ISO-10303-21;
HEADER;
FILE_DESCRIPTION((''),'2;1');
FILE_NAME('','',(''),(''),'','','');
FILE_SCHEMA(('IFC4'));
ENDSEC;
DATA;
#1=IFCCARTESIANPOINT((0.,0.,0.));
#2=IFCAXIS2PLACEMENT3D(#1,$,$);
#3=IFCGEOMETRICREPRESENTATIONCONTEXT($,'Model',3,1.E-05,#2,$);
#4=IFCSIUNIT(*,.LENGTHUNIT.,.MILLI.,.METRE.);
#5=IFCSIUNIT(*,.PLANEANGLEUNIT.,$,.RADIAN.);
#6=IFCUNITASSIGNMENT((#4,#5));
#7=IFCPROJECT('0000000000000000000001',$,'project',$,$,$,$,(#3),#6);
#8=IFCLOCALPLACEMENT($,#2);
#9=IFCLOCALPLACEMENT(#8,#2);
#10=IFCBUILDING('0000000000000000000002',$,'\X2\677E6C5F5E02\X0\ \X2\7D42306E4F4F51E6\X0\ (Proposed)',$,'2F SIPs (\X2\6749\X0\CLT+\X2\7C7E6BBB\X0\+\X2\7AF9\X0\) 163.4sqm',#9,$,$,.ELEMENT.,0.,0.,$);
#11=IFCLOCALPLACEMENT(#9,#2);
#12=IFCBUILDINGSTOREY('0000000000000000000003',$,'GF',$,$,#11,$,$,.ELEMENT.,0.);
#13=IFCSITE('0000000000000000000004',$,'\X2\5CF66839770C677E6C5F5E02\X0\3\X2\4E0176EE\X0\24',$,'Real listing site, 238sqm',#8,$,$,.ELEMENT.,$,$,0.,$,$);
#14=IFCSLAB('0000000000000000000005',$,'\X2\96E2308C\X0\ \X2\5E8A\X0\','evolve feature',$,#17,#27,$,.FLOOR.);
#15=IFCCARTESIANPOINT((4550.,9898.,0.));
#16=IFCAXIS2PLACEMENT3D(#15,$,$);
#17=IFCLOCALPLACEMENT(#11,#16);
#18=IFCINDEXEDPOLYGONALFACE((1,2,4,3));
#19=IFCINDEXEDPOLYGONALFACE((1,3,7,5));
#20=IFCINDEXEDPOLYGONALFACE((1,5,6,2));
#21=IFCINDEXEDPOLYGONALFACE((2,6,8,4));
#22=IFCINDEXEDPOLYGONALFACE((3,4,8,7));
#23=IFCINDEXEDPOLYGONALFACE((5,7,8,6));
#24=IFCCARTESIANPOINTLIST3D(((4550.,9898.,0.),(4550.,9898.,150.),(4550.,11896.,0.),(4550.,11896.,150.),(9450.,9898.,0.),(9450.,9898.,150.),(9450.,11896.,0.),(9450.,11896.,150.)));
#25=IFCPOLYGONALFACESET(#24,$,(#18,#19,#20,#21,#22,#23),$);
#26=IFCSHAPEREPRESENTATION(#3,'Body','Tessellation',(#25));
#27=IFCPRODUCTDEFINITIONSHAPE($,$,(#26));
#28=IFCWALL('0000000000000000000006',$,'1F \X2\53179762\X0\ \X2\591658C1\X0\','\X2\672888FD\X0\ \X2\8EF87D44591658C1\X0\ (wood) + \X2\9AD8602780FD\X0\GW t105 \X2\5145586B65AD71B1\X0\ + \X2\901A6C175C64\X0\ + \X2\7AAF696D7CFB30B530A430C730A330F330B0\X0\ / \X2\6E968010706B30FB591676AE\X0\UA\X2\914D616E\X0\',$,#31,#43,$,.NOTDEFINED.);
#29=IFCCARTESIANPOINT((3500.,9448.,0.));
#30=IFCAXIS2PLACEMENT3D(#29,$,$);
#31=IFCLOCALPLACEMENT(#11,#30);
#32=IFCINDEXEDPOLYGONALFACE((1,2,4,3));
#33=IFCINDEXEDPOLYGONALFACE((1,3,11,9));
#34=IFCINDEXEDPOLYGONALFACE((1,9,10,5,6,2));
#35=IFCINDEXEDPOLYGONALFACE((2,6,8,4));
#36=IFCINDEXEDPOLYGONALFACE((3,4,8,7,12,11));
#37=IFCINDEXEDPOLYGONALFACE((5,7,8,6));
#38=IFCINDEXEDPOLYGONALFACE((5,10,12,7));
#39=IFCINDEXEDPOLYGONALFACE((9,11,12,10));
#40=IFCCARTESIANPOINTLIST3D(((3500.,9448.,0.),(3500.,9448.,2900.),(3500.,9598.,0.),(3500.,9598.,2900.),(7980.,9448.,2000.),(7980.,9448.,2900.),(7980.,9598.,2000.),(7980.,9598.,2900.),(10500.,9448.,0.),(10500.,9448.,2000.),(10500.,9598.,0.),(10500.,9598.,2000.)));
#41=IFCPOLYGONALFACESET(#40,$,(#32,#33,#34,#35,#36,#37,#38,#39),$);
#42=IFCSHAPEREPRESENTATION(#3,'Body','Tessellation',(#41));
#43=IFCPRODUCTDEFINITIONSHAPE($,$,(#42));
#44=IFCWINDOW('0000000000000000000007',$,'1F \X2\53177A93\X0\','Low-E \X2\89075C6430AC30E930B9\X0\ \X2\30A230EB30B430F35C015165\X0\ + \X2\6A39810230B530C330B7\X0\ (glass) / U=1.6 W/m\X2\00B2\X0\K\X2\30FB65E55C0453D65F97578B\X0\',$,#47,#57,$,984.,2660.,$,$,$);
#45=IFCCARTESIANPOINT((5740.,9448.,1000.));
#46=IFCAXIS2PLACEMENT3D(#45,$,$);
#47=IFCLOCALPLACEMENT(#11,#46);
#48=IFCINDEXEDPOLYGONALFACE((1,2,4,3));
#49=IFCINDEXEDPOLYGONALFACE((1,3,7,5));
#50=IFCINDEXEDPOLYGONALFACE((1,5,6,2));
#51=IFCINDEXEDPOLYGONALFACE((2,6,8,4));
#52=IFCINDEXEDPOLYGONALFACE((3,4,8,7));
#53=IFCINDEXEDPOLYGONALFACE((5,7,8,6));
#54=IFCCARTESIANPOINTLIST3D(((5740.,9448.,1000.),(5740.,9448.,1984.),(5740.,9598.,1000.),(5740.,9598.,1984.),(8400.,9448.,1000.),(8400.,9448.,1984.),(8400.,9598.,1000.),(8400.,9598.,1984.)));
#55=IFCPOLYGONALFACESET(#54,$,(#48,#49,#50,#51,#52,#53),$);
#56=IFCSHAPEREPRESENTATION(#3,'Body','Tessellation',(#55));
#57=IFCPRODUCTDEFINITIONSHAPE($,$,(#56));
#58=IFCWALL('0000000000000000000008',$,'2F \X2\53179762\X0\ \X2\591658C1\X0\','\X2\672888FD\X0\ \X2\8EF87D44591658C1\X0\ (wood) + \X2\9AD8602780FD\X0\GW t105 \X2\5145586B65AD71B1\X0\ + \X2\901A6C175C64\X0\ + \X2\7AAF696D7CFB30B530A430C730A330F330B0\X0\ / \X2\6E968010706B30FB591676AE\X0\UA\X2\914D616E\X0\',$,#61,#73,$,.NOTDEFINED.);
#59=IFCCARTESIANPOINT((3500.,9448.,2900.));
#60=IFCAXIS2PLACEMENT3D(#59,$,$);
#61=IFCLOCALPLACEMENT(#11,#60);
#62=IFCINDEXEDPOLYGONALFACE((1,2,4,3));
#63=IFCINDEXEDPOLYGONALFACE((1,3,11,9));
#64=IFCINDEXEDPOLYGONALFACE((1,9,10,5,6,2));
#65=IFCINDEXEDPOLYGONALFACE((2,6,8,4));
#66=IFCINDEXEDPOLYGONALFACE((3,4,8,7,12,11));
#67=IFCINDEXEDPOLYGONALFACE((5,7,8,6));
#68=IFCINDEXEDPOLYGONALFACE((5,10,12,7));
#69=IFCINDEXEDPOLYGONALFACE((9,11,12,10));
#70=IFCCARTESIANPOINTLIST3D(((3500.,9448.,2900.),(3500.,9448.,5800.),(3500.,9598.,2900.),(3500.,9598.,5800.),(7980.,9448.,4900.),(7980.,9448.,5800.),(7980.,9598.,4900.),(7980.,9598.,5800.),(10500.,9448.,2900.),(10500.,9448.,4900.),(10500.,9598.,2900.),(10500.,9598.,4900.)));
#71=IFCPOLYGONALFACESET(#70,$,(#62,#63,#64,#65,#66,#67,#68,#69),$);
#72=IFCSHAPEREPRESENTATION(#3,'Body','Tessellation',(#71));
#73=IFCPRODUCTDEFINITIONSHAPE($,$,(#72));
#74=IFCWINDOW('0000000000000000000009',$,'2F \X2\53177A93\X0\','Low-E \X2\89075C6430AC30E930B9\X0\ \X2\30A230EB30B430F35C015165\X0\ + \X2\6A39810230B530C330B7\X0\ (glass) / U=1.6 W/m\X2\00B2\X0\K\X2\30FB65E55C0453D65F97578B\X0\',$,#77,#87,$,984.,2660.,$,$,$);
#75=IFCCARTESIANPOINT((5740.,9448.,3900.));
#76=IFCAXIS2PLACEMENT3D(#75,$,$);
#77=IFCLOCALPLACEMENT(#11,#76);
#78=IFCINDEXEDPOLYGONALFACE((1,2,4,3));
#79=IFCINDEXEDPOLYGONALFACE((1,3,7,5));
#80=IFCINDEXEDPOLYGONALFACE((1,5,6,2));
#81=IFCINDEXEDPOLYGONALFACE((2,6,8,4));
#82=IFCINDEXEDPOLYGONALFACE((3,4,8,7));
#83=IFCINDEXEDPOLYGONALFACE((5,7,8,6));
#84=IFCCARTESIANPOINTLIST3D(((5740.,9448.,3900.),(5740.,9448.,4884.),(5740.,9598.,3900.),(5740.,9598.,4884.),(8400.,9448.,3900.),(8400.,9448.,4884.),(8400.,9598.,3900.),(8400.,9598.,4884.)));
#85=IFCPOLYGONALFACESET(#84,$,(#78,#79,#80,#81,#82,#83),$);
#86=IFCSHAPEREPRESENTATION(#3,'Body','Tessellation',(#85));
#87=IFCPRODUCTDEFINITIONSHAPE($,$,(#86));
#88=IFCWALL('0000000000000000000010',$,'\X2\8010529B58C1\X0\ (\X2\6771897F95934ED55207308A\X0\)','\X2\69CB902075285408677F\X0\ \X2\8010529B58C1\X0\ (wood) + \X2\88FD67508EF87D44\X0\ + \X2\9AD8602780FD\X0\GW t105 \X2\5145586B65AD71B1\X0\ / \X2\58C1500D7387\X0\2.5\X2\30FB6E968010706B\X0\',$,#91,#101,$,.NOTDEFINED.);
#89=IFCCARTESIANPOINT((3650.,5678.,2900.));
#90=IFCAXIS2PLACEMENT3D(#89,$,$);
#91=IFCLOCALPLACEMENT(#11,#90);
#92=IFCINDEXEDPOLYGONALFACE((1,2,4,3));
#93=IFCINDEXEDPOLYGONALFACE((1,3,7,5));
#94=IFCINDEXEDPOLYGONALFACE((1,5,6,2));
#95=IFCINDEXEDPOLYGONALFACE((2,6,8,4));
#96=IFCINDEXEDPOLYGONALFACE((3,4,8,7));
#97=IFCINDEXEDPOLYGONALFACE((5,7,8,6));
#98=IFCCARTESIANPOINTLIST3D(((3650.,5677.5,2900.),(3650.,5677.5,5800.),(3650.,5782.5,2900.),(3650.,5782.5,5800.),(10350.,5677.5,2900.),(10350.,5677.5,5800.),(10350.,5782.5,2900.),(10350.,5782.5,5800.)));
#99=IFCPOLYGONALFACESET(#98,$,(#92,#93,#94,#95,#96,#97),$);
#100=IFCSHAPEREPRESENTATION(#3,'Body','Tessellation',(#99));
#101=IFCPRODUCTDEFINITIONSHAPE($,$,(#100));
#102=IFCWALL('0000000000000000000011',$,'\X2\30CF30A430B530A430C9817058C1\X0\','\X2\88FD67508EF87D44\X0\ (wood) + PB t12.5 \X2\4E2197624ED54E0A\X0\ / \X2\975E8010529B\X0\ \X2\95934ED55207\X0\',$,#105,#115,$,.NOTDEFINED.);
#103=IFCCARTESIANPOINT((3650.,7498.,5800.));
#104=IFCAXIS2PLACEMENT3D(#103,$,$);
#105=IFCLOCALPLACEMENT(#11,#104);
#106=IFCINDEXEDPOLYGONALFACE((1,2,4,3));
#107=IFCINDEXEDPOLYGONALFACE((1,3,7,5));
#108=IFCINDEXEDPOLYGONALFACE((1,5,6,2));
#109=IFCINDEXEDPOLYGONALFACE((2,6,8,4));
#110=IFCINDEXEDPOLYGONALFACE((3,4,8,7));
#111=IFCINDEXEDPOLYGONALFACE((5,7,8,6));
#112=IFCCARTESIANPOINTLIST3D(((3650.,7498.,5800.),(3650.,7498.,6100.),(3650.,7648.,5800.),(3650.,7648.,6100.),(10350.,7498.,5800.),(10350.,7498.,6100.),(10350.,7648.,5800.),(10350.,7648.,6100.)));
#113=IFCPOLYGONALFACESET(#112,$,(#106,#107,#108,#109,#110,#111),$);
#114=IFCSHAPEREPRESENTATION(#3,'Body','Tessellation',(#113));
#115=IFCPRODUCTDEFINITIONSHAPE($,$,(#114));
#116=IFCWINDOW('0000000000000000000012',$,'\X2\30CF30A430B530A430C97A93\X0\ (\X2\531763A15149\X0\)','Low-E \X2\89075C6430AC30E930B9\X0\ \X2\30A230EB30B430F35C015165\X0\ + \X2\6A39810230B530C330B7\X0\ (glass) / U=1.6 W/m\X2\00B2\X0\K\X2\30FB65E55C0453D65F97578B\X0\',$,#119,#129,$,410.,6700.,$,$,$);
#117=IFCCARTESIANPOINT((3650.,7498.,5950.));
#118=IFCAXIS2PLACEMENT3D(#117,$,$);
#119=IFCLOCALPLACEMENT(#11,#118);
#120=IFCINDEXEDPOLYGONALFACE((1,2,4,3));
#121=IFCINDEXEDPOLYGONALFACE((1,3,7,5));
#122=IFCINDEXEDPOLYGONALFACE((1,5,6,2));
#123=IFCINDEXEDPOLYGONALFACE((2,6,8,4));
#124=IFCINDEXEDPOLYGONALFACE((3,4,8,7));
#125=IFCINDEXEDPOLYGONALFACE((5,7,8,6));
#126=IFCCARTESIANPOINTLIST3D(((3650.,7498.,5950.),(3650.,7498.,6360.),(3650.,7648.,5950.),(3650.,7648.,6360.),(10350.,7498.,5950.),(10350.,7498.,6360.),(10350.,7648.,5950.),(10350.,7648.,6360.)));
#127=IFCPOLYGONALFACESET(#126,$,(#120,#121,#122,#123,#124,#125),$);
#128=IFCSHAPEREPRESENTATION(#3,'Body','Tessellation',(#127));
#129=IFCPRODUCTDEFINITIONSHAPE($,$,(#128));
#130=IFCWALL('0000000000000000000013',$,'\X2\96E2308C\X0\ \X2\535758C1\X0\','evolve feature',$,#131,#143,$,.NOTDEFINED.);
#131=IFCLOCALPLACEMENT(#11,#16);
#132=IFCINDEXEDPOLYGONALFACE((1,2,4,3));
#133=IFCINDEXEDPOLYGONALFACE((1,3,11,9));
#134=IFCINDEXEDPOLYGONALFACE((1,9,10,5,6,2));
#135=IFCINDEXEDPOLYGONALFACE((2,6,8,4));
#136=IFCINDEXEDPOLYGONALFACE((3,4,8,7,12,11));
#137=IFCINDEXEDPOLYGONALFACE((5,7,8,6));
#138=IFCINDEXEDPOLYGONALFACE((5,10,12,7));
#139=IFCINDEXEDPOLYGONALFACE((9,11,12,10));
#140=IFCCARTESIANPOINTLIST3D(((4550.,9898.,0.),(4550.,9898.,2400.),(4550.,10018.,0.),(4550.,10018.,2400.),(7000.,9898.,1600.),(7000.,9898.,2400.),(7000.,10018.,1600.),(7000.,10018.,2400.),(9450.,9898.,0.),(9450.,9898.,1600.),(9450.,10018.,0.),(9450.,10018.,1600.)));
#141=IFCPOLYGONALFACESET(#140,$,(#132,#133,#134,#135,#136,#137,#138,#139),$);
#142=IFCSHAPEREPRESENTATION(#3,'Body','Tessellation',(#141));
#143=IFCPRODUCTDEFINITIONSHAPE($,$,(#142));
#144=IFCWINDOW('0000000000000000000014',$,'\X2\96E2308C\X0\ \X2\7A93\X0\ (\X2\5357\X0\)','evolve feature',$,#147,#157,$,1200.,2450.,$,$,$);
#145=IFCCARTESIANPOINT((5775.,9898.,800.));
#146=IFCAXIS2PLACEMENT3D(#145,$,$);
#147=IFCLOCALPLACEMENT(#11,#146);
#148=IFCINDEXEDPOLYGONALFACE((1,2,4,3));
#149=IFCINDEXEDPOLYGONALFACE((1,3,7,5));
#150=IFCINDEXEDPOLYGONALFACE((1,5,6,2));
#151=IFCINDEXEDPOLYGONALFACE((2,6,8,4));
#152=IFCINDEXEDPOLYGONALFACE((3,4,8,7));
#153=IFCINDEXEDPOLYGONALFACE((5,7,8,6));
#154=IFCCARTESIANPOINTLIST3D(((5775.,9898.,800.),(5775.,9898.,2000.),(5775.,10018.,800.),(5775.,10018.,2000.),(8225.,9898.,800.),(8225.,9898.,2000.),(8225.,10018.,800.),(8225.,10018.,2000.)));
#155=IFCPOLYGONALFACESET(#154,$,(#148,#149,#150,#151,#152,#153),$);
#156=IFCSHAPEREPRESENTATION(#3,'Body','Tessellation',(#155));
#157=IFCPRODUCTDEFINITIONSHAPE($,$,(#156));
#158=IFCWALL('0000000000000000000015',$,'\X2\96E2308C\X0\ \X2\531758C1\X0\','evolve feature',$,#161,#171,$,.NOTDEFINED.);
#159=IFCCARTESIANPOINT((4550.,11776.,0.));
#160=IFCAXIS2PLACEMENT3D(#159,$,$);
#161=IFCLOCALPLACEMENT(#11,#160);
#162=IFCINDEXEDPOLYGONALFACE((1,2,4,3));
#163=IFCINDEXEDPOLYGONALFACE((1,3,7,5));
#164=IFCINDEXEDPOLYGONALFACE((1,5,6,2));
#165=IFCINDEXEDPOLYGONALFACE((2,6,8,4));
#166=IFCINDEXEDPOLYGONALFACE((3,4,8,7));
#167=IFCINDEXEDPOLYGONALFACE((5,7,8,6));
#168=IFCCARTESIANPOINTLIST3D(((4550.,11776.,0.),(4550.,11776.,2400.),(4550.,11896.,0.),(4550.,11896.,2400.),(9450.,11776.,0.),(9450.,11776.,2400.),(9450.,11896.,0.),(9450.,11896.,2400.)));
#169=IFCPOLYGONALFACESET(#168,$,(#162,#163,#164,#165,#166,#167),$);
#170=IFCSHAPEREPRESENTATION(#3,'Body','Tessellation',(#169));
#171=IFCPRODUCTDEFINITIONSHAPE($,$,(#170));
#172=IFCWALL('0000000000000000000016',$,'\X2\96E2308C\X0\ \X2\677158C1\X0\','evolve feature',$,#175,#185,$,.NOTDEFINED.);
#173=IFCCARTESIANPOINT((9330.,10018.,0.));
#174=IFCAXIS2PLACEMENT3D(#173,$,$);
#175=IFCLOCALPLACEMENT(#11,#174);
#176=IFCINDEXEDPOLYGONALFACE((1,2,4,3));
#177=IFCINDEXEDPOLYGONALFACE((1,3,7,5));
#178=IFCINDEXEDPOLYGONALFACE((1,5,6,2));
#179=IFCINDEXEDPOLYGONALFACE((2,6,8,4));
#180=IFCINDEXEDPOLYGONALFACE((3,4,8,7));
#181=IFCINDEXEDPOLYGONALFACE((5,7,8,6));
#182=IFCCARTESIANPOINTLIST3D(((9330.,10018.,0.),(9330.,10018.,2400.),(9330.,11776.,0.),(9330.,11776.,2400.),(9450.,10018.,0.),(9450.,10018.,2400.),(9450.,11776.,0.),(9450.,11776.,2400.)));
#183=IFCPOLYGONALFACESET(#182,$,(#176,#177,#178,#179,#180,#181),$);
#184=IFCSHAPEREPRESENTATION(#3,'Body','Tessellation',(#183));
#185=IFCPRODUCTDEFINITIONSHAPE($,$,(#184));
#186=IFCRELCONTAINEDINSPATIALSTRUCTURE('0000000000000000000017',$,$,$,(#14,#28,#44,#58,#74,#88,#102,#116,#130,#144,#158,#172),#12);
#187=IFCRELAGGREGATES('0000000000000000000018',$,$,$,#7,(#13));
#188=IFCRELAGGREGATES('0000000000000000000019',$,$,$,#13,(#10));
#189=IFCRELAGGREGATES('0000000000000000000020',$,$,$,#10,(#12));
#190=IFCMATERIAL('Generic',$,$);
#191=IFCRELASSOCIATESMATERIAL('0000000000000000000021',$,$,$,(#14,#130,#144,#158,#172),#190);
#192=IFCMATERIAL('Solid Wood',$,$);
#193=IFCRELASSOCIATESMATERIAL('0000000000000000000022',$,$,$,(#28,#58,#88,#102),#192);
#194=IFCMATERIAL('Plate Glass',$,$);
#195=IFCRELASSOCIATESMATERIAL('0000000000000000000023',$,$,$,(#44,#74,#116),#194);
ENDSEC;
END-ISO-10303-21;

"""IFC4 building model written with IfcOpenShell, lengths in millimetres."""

from ifc_helpers import new_model, si_unit, frame, frame_2d, origin, place, context, project, spatial, rectangle, extrude, material, element, fill, save


model = new_model("IFC4")

# Units and contexts
model_context = context("Model", 3, precision=1e-05, world=origin())
ifc_project = project(units=[si_unit("LENGTHUNIT", "METRE", prefix="MILLI"), si_unit("PLANEANGLEUNIT", "RADIAN")], contexts=[model_context])

# Site, building, storey
site_placement = place(None, origin())
site = spatial("IfcSite", under=ifc_project, at=site_placement, Name="島根県松江市3丁目24", ObjectType="Real listing site, 238sqm", CompositionType="ELEMENT", RefElevation=0.0)
building_placement = place(site_placement, origin())
building = spatial("IfcBuilding", under=site, at=building_placement, Name="松江市 終の住処 (Proposed)", ObjectType="2F SIPs (杉CLT+籾殻+竹) 163.4sqm", CompositionType="ELEMENT", ElevationOfRefHeight=0.0, ElevationOfTerrain=0.0)
storey_placement = place(building_placement, origin())
storey = spatial("IfcBuildingStorey", under=building, at=storey_placement, Name="GF", CompositionType="ELEMENT", Elevation=0.0)

# Slab
ifc_material_1 = material(Name="Generic")
slab_placement = place(storey_placement, frame((4550.0, 9898.0, 0.0)))
element("IfcSlab", 1, at=slab_placement, inside=storey, material=ifc_material_1, Name="離れ 床", Description="evolve feature", PredefinedType="FLOOR", context=model_context, shape_type="SweptSolid", body=[
    extrude(rectangle(XDim=4900.0, YDim=1998.0, at=frame_2d((2450.0, 999.0))), frame((4550.0, 9898.0, 0.0)), (0.0, 0.0, 1.0), 150.0),
])

# Wall, opening, window
ifc_material_2 = material(Name="Solid Wood")
wall_1_placement = place(storey_placement, frame((3500.0, 9448.0, 0.0)))
wall_1 = element("IfcWall", 2, at=wall_1_placement, inside=storey, material=ifc_material_2, Name="1F 北面 外壁", Description="木製 軸組外壁 (wood) + 高性能GW t105 充填断熱 + 通気層 + 窯業系サイディング / 準耐火・外皮UA配慮", PredefinedType="NOTDEFINED", context=model_context, shape_type="SweptSolid", body=[
    extrude(rectangle(XDim=7000.0, YDim=150.0, at=frame_2d((3500.0, 75.0))), frame((3500.0, 9448.0, 0.0)), (0.0, 0.0, 1.0), 2900.0),
])
opening_1_placement = place(storey_placement, frame((5740.0, 9448.0, 1000.0)))
opening_1 = element("IfcOpeningElement", 3, at=opening_1_placement, cuts=wall_1, PredefinedType="NOTDEFINED", context=model_context, shape_type="SweptSolid", body=[
    extrude(rectangle(XDim=2660.0, YDim=150.0, at=frame_2d((1330.0, 75.0))), frame((5740.0, 9448.0, 1000.0)), (0.0, 0.0, 1.0), 984.0),
])
ifc_material_3 = material(Name="Plate Glass")
window_1_placement = place(storey_placement, frame((5740.0, 9448.0, 1000.0)))
window_1 = element("IfcWindow", 4, at=window_1_placement, inside=storey, material=ifc_material_3, Name="1F 北窓", Description="Low-E 複層ガラス アルゴン封入 + 樹脂サッシ (glass) / U=1.6 W/m²K・日射取得型", OverallHeight=984.0, OverallWidth=2660.0, context=model_context, shape_type="SweptSolid", body=[
    extrude(rectangle(XDim=2660.0, YDim=150.0, at=frame_2d((1330.0, 75.0))), frame((5740.0, 9448.0, 1000.0)), (0.0, 0.0, 1.0), 984.0),
])
fill(opening_1, window_1)

# Wall, opening, window
wall_2_placement = place(storey_placement, frame((3500.0, 9448.0, 2900.0)))
wall_2 = element("IfcWall", 5, at=wall_2_placement, inside=storey, material=ifc_material_2, Name="2F 北面 外壁", Description="木製 軸組外壁 (wood) + 高性能GW t105 充填断熱 + 通気層 + 窯業系サイディング / 準耐火・外皮UA配慮", PredefinedType="NOTDEFINED", context=model_context, shape_type="SweptSolid", body=[
    extrude(rectangle(XDim=7000.0, YDim=150.0, at=frame_2d((3500.0, 75.0))), frame((3500.0, 9448.0, 2900.0)), (0.0, 0.0, 1.0), 2900.0),
])
opening_2_placement = place(storey_placement, frame((5740.0, 9448.0, 3900.0)))
opening_2 = element("IfcOpeningElement", 6, at=opening_2_placement, cuts=wall_2, PredefinedType="NOTDEFINED", context=model_context, shape_type="SweptSolid", body=[
    extrude(rectangle(XDim=2660.0, YDim=150.0, at=frame_2d((1330.0, 75.0))), frame((5740.0, 9448.0, 3900.0)), (0.0, 0.0, 1.0), 984.0),
])
window_2_placement = place(storey_placement, frame((5740.0, 9448.0, 3900.0)))
window_2 = element("IfcWindow", 7, at=window_2_placement, inside=storey, material=ifc_material_3, Name="2F 北窓", Description="Low-E 複層ガラス アルゴン封入 + 樹脂サッシ (glass) / U=1.6 W/m²K・日射取得型", OverallHeight=984.0, OverallWidth=2660.0, context=model_context, shape_type="SweptSolid", body=[
    extrude(rectangle(XDim=2660.0, YDim=150.0, at=frame_2d((1330.0, 75.0))), frame((5740.0, 9448.0, 3900.0)), (0.0, 0.0, 1.0), 984.0),
])
fill(opening_2, window_2)

# Wall
wall_3_placement = place(storey_placement, frame((3650.0, 5678.0, 2900.0)))
element("IfcWall", 8, at=wall_3_placement, inside=storey, material=ifc_material_2, Name="耐力壁 (東西間仕切り)", Description="構造用合板 耐力壁 (wood) + 製材軸組 + 高性能GW t105 充填断熱 / 壁倍率2.5・準耐火", PredefinedType="NOTDEFINED", context=model_context, shape_type="SweptSolid", body=[
    extrude(rectangle(XDim=6700.0, YDim=105.0, at=frame_2d((3350.0, 52.0))), frame((3650.0, 5678.0, 2900.0)), (0.0, 0.0, 1.0), 2900.0),
])

# Walls, openings, windows
wall_4_placement = place(storey_placement, frame((3650.0, 7498.0, 5800.0)))
wall_4 = element("IfcWall", 9, at=wall_4_placement, inside=storey, material=ifc_material_2, Name="ハイサイド腰壁", Description="製材軸組 (wood) + PB t12.5 両面仕上 / 非耐力 間仕切", PredefinedType="NOTDEFINED", context=model_context, shape_type="SweptSolid", body=[
    extrude(rectangle(XDim=6700.0, YDim=150.0, at=frame_2d((3350.0, 75.0))), frame((3650.0, 7498.0, 5800.0)), (0.0, 0.0, 1.0), 700.0),
])
opening_3_placement = place(storey_placement, frame((3650.0, 7498.0, 5950.0)))
opening_3 = element("IfcOpeningElement", 10, at=opening_3_placement, cuts=wall_4, PredefinedType="NOTDEFINED", context=model_context, shape_type="SweptSolid", body=[
    extrude(rectangle(XDim=6700.0, YDim=150.0, at=frame_2d((3350.0, 75.0))), frame((3650.0, 7498.0, 5950.0)), (0.0, 0.0, 1.0), 410.0),
])
window_3_placement = place(storey_placement, frame((3650.0, 7498.0, 5950.0)))
window_3 = element("IfcWindow", 11, at=window_3_placement, inside=storey, material=ifc_material_3, Name="ハイサイド窓 (北採光)", Description="Low-E 複層ガラス アルゴン封入 + 樹脂サッシ (glass) / U=1.6 W/m²K・日射取得型", OverallHeight=410.0, OverallWidth=6700.0, context=model_context, shape_type="SweptSolid", body=[
    extrude(rectangle(XDim=6700.0, YDim=150.0, at=frame_2d((3350.0, 75.0))), frame((3650.0, 7498.0, 5950.0)), (0.0, 0.0, 1.0), 410.0),
])
fill(opening_3, window_3)
wall_5_placement = place(storey_placement, frame((4550.0, 9898.0, 0.0)))
wall_5 = element("IfcWall", 12, at=wall_5_placement, inside=storey, material=ifc_material_1, Name="離れ 南壁", Description="evolve feature", PredefinedType="NOTDEFINED", context=model_context, shape_type="SweptSolid", body=[
    extrude(rectangle(XDim=4900.0, YDim=120.0, at=frame_2d((2450.0, 60.0))), frame((4550.0, 9898.0, 0.0)), (0.0, 0.0, 1.0), 2400.0),
])
opening_4_placement = place(storey_placement, frame((5775.0, 9898.0, 800.0)))
opening_4 = element("IfcOpeningElement", 13, at=opening_4_placement, cuts=wall_5, PredefinedType="NOTDEFINED", context=model_context, shape_type="SweptSolid", body=[
    extrude(rectangle(XDim=2450.0, YDim=120.0, at=frame_2d((1225.0, 60.0))), frame((5775.0, 9898.0, 800.0)), (0.0, 0.0, 1.0), 1200.0),
])
window_4_placement = place(storey_placement, frame((5775.0, 9898.0, 800.0)))
window_4 = element("IfcWindow", 14, at=window_4_placement, inside=storey, material=ifc_material_1, Name="離れ 窓 (南)", Description="evolve feature", OverallHeight=1200.0, OverallWidth=2450.0, context=model_context, shape_type="SweptSolid", body=[
    extrude(rectangle(XDim=2450.0, YDim=120.0, at=frame_2d((1225.0, 60.0))), frame((5775.0, 9898.0, 800.0)), (0.0, 0.0, 1.0), 1200.0),
])
fill(opening_4, window_4)

# Walls
wall_6_placement = place(storey_placement, frame((4550.0, 11776.0, 0.0)))
element("IfcWall", 15, at=wall_6_placement, inside=storey, material=ifc_material_1, Name="離れ 北壁", Description="evolve feature", PredefinedType="NOTDEFINED", context=model_context, shape_type="SweptSolid", body=[
    extrude(rectangle(XDim=4900.0, YDim=120.0, at=frame_2d((2450.0, 60.0))), frame((4550.0, 11776.0, 0.0)), (0.0, 0.0, 1.0), 2400.0),
])
wall_7_placement = place(storey_placement, frame((9330.0, 10018.0, 0.0)))
element("IfcWall", 16, at=wall_7_placement, inside=storey, material=ifc_material_1, Name="離れ 東壁", Description="evolve feature", PredefinedType="NOTDEFINED", context=model_context, shape_type="SweptSolid", body=[
    extrude(rectangle(XDim=120.0, YDim=1758.0, at=frame_2d((60.0, 879.0))), frame((9330.0, 10018.0, 0.0)), (0.0, 0.0, 1.0), 2400.0),
])

save(model, "model.ifc")
